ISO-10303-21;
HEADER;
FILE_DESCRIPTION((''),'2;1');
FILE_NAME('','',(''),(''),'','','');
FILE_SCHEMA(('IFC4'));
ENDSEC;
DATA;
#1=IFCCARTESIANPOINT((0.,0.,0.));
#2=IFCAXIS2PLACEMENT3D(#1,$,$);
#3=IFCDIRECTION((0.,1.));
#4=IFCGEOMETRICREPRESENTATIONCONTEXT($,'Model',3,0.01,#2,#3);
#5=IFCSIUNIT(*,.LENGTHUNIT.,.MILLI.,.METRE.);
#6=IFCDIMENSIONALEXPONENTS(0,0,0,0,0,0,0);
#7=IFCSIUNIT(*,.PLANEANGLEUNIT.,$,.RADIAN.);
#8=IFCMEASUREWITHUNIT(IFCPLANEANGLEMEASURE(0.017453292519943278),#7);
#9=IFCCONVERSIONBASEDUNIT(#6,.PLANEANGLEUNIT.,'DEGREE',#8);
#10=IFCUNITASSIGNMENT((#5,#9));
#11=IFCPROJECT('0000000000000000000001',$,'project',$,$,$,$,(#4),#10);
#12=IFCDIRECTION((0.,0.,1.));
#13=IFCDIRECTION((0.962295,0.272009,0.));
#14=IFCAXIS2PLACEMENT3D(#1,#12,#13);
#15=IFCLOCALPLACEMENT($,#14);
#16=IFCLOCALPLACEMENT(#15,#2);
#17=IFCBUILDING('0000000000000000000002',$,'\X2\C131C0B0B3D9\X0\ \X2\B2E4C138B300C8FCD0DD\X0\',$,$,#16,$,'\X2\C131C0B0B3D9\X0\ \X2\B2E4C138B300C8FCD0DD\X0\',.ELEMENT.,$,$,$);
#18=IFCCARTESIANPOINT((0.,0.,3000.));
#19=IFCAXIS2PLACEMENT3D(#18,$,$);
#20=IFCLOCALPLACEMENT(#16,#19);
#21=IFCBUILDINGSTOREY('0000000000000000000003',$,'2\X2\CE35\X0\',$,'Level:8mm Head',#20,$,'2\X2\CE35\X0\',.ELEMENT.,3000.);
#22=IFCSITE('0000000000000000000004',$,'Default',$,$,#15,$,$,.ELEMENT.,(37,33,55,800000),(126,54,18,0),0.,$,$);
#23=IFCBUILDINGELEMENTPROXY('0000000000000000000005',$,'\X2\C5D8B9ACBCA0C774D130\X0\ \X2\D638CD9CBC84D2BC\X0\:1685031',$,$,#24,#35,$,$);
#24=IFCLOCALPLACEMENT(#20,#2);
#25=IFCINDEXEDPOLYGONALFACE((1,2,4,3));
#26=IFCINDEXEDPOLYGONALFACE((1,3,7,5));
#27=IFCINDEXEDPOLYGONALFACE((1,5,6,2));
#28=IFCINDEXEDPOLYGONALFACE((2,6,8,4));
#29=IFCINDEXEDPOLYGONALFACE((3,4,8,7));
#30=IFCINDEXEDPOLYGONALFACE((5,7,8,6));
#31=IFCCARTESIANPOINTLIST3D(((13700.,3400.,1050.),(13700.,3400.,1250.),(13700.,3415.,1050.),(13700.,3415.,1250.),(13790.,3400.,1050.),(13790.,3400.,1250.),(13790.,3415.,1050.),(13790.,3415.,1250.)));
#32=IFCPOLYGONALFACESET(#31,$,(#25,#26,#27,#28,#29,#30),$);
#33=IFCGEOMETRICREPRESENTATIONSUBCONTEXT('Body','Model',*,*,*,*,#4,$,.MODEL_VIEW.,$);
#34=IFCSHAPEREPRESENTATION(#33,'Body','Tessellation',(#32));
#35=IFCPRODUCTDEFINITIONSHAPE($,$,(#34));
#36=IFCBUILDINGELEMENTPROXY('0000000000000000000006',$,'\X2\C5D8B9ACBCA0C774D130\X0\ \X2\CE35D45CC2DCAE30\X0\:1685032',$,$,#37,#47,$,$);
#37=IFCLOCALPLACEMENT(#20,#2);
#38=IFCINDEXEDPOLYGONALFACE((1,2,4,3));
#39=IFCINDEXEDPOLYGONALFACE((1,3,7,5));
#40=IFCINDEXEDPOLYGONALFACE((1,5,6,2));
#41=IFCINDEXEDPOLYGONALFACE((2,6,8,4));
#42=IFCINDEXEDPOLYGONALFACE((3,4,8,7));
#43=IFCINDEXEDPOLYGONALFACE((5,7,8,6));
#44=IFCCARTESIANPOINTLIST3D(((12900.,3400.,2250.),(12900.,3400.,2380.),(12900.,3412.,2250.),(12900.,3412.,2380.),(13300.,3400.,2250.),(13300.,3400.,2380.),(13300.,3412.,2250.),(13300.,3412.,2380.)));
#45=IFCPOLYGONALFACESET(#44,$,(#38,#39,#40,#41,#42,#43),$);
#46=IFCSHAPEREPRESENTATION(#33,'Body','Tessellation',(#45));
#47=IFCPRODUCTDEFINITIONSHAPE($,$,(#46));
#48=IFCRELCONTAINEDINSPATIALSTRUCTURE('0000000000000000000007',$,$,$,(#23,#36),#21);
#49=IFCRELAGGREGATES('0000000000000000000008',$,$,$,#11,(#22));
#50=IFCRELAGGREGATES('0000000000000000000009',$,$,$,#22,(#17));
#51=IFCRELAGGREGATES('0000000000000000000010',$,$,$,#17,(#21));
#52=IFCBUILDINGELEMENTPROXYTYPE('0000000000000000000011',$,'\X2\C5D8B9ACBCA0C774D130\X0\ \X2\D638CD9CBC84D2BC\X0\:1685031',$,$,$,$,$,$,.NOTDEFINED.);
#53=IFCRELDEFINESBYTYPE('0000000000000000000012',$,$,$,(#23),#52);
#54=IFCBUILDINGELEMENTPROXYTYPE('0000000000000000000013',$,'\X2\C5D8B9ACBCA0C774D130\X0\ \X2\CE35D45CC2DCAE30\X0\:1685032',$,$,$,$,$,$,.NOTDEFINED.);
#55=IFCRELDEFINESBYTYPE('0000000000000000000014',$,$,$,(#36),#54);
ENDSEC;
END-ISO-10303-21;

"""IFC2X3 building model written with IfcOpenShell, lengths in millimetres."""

from ifc_helpers import new_model, entity, si_unit, converted_unit, direction, frame, frame_2d, origin, place, context, subcontext, project, spatial, rectangle, extrude, type_object, element, save


model = new_model("IFC2X3")

# Units and contexts
model_context = context("Model", 3, precision=0.01, world=origin(), true_north=direction((0.0, 1.0)))
body_context = subcontext(model_context, "Body", "Model", "MODEL_VIEW")
ifc_project = project(units=[si_unit("LENGTHUNIT", "METRE", prefix="MILLI"), converted_unit("PLANEANGLEUNIT", "DEGREE", entity("IfcPlaneAngleMeasure", 0.017453292519943278), si_unit("PLANEANGLEUNIT", "RADIAN"), dimensions=[0, 0, 0, 0, 0, 0, 0])], contexts=[model_context])

# Site, building, storey
site_placement = place(None, frame((0.0, 0.0, 0.0), z_axis=(0.0, 0.0, 1.0), x_axis=(0.962295, 0.272009, 0.0)))
site = spatial("IfcSite", under=ifc_project, at=site_placement, Name="Default", CompositionType="ELEMENT", RefLatitude=(37, 33, 55, 800000), RefLongitude=(126, 54, 18, 0), RefElevation=0.0)
building_placement = place(site_placement, origin())
building = spatial("IfcBuilding", under=site, at=building_placement, Name="성산동 다세대주택", LongName="성산동 다세대주택", CompositionType="ELEMENT")
storey_placement = place(building_placement, frame((0.0, 0.0, 3000.0)))
storey = spatial("IfcBuildingStorey", under=building, at=storey_placement, Name="2층", ObjectType="Level:8mm Head", LongName="2층", CompositionType="ELEMENT", Elevation=3000.0)

# Building element proxies
building_element_proxy_type_1 = type_object("IfcBuildingElementProxyType", Name="엘리베이터 호출버튼:1685031", PredefinedType="NOTDEFINED")
proxy_1_placement = place(storey_placement, origin())
element("IfcBuildingElementProxy", 1, at=proxy_1_placement, inside=storey, type_object=building_element_proxy_type_1, Name="엘리베이터 호출버튼:1685031", context=body_context, shape_type="SweptSolid", body=[
    extrude(rectangle(XDim=90.0, YDim=15.0, at=frame_2d((0.0, 0.0), x_axis=(1.0, 0.0))), frame((13745.0, 3407.5, 1050.0)), (0.0, 0.0, 1.0), 200.0),
])
building_element_proxy_type_2 = type_object("IfcBuildingElementProxyType", Name="엘리베이터 층표시기:1685032", PredefinedType="NOTDEFINED")
proxy_2_placement = place(storey_placement, origin())
element("IfcBuildingElementProxy", 2, at=proxy_2_placement, inside=storey, type_object=building_element_proxy_type_2, Name="엘리베이터 층표시기:1685032", context=body_context, shape_type="SweptSolid", body=[
    extrude(rectangle(XDim=400.0, YDim=12.0, at=frame_2d((0.0, 0.0), x_axis=(1.0, 0.0))), frame((13100.0, 3406.0, 2250.0)), (0.0, 0.0, 1.0), 130.0),
])

save(model, "model.ifc")
